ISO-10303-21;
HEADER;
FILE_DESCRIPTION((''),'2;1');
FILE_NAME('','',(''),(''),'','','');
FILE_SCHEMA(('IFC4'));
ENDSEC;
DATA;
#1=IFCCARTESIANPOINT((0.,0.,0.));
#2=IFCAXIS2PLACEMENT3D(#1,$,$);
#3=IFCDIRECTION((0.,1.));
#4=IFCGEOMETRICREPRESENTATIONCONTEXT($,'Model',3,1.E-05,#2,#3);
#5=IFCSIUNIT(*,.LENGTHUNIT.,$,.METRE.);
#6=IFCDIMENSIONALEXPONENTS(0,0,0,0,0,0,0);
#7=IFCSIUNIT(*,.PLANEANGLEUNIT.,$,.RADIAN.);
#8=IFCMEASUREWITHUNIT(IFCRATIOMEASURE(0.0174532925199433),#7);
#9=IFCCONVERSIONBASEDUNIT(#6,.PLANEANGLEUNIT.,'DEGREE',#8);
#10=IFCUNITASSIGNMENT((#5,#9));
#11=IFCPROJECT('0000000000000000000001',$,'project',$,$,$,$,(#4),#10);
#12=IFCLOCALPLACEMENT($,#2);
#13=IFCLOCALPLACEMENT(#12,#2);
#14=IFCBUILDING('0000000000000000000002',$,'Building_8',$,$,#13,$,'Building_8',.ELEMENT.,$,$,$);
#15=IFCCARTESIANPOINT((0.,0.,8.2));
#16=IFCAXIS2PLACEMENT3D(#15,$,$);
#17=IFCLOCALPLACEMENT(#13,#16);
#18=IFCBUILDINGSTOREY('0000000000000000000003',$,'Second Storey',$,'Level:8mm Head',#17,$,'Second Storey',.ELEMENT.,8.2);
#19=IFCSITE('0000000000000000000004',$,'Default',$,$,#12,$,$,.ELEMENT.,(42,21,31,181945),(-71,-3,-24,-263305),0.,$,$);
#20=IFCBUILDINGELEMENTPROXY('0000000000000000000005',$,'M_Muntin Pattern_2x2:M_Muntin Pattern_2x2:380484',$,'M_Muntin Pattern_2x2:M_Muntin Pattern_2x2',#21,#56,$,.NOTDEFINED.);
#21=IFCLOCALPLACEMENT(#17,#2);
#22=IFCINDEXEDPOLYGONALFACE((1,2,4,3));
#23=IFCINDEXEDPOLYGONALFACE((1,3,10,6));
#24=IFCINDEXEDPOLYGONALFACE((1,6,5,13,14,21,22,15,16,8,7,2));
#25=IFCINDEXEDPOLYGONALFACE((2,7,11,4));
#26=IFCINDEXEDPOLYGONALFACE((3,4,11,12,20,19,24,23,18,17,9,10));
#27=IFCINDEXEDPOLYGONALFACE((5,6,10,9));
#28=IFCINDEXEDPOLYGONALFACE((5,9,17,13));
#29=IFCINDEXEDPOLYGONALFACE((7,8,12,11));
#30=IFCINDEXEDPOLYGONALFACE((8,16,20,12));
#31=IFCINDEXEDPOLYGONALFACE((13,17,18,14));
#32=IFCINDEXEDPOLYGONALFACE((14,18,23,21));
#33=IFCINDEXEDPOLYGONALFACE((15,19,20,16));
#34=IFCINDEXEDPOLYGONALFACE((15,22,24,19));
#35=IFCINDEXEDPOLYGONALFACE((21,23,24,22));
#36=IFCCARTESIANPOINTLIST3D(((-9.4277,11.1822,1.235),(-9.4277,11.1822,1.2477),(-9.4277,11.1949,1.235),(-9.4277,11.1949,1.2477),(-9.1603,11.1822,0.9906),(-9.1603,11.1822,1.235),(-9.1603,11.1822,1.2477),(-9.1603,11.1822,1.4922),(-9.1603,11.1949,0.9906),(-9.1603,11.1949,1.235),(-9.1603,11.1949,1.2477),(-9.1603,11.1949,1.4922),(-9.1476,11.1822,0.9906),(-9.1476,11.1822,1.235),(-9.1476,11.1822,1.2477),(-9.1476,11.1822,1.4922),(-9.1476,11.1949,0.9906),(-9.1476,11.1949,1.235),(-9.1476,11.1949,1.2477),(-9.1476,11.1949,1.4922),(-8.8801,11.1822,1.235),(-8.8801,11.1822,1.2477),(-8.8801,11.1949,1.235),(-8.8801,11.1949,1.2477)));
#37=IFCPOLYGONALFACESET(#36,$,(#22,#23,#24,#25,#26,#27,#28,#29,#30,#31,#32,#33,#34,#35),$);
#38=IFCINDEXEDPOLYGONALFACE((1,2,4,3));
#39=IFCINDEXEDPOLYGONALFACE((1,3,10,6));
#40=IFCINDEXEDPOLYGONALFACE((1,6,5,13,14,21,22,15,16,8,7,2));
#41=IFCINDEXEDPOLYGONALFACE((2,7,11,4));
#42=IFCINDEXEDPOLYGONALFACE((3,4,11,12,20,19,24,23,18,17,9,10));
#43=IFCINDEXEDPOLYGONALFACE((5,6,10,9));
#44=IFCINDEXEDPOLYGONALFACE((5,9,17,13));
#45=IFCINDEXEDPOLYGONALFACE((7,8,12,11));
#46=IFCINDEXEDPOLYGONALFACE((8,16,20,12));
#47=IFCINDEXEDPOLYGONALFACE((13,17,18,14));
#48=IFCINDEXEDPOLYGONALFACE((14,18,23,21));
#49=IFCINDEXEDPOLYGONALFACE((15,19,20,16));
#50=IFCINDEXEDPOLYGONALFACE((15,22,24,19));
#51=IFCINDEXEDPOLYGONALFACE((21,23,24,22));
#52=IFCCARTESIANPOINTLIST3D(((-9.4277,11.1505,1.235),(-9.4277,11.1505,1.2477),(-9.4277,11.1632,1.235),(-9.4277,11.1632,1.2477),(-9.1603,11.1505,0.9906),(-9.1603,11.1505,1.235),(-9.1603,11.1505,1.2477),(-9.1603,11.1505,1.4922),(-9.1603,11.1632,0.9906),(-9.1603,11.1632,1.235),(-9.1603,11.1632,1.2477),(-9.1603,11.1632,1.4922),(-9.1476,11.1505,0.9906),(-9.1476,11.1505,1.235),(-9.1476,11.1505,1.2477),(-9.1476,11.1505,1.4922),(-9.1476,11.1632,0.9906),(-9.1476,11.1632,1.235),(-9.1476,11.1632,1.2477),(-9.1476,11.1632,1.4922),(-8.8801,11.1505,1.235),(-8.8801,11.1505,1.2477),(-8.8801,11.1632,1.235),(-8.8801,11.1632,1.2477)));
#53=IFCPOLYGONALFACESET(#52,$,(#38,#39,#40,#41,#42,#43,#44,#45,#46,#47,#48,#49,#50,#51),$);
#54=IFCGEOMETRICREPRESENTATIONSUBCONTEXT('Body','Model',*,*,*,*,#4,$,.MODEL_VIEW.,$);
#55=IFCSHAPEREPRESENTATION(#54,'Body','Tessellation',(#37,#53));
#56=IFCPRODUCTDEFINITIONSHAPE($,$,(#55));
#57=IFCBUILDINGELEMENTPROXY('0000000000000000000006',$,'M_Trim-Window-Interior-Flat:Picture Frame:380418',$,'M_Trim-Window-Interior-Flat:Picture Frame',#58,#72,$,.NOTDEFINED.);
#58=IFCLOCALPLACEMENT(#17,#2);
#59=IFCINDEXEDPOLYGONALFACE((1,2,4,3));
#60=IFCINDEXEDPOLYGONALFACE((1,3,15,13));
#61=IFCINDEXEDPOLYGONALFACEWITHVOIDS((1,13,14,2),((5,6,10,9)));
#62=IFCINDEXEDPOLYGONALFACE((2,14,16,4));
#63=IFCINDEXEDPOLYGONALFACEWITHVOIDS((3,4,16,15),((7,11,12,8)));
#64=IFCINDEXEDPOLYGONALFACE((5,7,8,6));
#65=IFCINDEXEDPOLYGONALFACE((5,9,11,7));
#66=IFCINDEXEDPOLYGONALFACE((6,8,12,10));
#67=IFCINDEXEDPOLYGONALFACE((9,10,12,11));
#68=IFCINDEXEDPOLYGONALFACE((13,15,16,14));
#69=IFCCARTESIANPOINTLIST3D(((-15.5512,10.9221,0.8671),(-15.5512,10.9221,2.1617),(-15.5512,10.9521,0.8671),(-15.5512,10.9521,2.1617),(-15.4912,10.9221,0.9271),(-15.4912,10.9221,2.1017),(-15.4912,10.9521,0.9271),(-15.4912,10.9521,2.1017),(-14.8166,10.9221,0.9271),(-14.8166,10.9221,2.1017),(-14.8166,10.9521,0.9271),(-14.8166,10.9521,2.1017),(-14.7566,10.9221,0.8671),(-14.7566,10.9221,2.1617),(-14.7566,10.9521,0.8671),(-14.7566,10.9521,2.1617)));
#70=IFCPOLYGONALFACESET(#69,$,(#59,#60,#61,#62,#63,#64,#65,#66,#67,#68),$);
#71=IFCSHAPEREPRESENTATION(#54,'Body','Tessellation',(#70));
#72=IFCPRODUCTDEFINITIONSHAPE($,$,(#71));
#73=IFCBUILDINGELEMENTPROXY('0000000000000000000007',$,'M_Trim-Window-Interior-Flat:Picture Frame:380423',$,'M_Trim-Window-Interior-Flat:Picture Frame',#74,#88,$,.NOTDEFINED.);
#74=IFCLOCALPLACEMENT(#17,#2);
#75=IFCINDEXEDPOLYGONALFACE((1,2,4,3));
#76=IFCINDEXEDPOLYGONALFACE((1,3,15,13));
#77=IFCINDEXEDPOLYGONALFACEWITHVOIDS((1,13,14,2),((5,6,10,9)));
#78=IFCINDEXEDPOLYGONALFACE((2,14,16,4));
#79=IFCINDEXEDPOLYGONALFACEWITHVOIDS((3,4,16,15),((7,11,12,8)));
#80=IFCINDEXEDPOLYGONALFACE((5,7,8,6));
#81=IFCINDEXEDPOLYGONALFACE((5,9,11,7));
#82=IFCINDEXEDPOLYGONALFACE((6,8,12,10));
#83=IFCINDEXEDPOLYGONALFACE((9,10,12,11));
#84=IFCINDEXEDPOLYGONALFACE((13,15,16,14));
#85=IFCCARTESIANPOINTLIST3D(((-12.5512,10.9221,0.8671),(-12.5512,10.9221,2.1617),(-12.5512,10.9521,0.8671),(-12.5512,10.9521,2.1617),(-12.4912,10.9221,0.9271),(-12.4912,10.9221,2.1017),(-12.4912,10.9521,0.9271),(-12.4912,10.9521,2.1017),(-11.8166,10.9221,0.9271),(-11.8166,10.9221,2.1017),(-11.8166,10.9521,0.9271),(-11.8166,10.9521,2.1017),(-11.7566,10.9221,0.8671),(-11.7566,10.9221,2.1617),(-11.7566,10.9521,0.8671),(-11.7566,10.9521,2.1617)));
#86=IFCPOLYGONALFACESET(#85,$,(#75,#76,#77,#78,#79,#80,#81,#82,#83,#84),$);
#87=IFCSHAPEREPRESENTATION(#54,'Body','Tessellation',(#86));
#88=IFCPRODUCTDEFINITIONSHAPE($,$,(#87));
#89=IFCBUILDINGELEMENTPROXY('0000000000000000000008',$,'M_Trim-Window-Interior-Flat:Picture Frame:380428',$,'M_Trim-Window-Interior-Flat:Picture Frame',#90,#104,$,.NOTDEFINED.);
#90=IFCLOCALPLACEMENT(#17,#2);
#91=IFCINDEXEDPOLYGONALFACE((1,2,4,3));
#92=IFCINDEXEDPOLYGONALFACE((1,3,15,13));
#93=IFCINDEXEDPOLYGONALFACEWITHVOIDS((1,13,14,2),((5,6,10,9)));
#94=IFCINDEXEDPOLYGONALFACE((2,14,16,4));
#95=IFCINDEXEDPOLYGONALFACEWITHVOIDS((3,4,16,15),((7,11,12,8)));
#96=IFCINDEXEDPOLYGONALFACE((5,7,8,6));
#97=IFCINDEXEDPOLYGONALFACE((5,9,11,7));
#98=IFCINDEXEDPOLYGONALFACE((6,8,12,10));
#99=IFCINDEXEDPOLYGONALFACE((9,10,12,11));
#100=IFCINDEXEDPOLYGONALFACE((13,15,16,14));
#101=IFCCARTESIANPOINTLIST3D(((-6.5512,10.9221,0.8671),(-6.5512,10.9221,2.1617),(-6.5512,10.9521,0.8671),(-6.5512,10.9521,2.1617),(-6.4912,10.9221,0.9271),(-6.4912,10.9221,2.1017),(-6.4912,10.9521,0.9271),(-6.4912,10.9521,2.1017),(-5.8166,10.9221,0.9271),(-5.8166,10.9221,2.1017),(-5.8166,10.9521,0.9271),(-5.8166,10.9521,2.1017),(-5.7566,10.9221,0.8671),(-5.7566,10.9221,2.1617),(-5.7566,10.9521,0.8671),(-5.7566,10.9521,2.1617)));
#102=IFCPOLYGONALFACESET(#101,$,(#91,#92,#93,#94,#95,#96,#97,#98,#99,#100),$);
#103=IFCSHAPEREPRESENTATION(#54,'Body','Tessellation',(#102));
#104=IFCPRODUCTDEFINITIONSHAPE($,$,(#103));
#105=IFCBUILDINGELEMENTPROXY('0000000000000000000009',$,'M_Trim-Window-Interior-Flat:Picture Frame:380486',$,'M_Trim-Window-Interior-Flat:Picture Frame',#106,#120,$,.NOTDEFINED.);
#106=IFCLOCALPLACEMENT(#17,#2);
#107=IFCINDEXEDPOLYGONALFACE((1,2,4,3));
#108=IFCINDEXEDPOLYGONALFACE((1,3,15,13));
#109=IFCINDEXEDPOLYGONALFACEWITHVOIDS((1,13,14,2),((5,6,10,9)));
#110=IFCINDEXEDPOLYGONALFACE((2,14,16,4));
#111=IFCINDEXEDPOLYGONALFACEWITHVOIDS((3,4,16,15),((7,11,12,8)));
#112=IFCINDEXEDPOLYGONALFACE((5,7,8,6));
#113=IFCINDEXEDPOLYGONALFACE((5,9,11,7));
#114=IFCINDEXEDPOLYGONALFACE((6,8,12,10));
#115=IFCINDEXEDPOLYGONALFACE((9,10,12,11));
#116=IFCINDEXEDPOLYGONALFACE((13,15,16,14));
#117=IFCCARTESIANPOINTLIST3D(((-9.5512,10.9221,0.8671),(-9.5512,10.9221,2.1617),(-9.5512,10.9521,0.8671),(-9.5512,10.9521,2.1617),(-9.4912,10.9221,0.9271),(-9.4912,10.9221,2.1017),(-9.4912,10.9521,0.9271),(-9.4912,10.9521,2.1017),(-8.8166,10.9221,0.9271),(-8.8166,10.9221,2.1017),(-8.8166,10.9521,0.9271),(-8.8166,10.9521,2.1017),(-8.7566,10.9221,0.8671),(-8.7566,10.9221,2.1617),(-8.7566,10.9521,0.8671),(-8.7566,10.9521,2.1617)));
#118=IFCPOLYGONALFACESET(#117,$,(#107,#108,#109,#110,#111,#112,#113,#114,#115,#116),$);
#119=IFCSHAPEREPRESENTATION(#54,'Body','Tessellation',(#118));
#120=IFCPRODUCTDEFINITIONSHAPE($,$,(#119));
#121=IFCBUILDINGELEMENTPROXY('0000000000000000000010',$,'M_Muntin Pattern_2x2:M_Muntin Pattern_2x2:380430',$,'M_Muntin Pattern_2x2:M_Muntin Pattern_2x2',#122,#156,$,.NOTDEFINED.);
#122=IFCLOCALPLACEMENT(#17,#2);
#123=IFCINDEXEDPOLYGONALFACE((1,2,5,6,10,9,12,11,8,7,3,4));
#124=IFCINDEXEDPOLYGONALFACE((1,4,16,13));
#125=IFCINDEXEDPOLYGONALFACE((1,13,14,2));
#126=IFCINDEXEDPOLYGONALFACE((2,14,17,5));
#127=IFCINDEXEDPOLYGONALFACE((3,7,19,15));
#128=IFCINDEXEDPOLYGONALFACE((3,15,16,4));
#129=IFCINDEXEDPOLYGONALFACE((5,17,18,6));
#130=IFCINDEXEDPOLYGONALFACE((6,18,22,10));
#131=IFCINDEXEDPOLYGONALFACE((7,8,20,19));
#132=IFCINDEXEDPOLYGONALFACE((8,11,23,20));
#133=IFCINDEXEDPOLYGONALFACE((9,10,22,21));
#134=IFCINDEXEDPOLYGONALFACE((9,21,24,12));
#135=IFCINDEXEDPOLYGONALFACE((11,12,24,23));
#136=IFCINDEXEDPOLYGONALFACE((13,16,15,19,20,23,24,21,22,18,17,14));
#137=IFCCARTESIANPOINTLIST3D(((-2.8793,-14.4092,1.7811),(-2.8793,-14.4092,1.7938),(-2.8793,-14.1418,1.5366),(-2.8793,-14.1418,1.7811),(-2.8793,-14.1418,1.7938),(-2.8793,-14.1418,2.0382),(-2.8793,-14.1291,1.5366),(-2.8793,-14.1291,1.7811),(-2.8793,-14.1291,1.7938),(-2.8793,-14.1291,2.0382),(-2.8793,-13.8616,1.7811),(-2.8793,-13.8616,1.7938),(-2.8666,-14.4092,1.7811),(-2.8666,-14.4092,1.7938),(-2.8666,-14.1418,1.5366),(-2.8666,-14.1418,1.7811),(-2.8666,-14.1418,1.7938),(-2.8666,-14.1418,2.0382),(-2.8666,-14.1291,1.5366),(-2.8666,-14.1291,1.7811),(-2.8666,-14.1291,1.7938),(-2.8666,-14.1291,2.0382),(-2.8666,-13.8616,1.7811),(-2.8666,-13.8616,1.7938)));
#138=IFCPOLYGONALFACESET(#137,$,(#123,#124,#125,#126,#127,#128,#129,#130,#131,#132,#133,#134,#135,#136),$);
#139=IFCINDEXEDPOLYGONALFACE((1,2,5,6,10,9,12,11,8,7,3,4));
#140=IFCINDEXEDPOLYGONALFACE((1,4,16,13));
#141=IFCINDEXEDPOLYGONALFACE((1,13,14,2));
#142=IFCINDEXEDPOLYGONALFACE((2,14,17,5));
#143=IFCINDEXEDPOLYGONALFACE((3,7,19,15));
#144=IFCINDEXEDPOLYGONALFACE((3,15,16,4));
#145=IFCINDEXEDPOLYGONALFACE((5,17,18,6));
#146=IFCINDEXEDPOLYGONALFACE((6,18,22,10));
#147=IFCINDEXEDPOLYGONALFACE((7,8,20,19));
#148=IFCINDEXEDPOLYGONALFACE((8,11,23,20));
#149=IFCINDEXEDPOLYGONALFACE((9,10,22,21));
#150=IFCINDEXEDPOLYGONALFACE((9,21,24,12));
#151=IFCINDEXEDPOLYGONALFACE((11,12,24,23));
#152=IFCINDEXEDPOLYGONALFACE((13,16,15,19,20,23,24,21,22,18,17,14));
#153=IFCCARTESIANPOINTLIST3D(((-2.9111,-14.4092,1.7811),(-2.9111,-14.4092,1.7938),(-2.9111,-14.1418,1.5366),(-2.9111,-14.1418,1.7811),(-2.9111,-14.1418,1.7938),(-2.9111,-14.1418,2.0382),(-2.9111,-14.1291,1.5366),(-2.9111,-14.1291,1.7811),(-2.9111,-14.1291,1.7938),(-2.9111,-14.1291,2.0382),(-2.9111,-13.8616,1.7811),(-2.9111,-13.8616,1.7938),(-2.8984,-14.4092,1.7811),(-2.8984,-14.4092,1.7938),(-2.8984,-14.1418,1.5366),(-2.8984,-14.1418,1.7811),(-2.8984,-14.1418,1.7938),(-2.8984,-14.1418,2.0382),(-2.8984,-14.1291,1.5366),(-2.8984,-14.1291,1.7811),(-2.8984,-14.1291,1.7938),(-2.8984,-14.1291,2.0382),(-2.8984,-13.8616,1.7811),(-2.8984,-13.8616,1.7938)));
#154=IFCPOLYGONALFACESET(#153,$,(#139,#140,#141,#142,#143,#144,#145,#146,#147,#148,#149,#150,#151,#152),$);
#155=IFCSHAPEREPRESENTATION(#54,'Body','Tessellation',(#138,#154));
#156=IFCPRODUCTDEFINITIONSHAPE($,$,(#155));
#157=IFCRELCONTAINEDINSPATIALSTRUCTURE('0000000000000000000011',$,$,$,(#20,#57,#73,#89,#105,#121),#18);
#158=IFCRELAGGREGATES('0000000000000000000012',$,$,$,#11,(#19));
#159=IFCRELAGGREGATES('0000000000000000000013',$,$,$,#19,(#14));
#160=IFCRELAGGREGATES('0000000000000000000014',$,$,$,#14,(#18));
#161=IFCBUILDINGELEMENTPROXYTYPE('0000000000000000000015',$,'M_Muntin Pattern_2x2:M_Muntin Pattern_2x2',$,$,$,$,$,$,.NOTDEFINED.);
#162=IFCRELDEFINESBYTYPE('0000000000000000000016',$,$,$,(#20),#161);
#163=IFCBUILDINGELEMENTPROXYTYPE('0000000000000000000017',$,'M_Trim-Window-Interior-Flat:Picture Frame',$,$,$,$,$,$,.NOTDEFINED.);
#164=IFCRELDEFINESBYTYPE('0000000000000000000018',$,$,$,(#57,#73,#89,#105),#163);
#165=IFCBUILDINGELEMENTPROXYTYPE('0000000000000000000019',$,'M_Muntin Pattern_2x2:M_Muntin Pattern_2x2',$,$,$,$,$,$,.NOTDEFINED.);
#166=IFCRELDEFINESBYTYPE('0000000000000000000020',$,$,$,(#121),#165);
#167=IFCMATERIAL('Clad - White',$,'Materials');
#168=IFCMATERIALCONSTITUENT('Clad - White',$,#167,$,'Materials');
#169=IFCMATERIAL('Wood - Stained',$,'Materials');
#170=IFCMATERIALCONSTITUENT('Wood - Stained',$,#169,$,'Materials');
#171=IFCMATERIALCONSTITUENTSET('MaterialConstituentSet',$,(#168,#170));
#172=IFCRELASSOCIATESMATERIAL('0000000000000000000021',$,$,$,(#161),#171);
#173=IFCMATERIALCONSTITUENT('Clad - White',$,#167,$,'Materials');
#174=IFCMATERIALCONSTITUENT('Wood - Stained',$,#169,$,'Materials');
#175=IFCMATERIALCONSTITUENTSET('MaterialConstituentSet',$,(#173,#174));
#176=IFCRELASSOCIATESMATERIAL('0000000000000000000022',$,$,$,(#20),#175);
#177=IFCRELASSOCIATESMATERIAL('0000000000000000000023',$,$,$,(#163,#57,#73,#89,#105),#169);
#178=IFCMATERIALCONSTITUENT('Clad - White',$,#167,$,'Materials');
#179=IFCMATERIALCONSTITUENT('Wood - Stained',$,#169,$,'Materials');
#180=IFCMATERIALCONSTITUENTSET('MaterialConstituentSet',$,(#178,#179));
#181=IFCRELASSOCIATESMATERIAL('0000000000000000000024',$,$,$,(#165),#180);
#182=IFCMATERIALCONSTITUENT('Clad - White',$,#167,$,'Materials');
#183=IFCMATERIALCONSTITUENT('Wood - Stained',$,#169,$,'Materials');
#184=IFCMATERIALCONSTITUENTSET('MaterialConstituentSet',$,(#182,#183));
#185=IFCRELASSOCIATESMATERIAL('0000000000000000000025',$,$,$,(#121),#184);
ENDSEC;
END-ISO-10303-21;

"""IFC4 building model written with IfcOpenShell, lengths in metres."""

from ifc_helpers import new_model, entity, si_unit, converted_unit, direction, frame, origin, place, context, subcontext, project, spatial, indexed_curve, outline, extrude, source, transform, mapped, material, constituent, constituent_set, type_object, type_shapes, element, save


model = new_model("IFC4")

# Units and contexts
model_context = context("Model", 3, precision=1e-05, world=origin(), true_north=direction((0.0, 1.0)))
body_context = subcontext(model_context, "Body", "Model", "MODEL_VIEW")
ifc_project = project(units=[si_unit("LENGTHUNIT", "METRE"), converted_unit("PLANEANGLEUNIT", "DEGREE", entity("IfcRatioMeasure", 0.0174532925199433), si_unit("PLANEANGLEUNIT", "RADIAN"), dimensions=[0, 0, 0, 0, 0, 0, 0])], contexts=[model_context])

# Site, building, storey
site_placement = place(None, origin())
site = spatial("IfcSite", under=ifc_project, at=site_placement, Name="Default", CompositionType="ELEMENT", RefLatitude=(42, 21, 31, 181945), RefLongitude=(-71, -3, -24, -263305), RefElevation=0.0)
building_placement = place(site_placement, origin())
building = spatial("IfcBuilding", under=site, at=building_placement, Name="Building_8", LongName="Building_8", CompositionType="ELEMENT")
storey_placement = place(building_placement, frame((0.0, 0.0, 8.2)))
storey = spatial("IfcBuildingStorey", under=building, at=storey_placement, Name="Second Storey", ObjectType="Level:8mm Head", LongName="Second Storey", CompositionType="ELEMENT", Elevation=8.2)

# Building element proxies
ifc_material_1 = material(Name="Clad - White", Category="Materials")
ifc_material_2 = material(Name="Wood - Stained", Category="Materials")
ifc_constituent_1 = constituent(ifc_material_1, Name="Clad - White", Category="Materials")
ifc_constituent_2 = constituent(ifc_material_2, Name="Wood - Stained", Category="Materials")
ifc_constituent_set_1 = constituent_set(constituents=[ifc_constituent_1, ifc_constituent_2], Name="MaterialConstituentSet")
building_element_proxy_type_1 = type_object("IfcBuildingElementProxyType", Name="M_Muntin Pattern_2x2:M_Muntin Pattern_2x2", PredefinedType="NOTDEFINED", material=ifc_constituent_set_1)
shared_shape_1 = source(origin(), body_context, "Body", "SweptSolid", [
    extrude(outline(indexed_curve([(0.0064, -0.0064), (0.2508, -0.0064), (0.2508, 0.0063), (0.0064, 0.0063), (0.0064, 0.2738), (-0.0063, 0.2738), (-0.0063, 0.0063), (-0.2508, 0.0063), (-0.2508, -0.0064), (-0.0063, -0.0064), (-0.0063, -0.2738), (0.0064, -0.2738), (0.0064, -0.0064)], self_intersect=False)), frame((0.0, -0.0222, 0.2508), z_axis=(0.0, 1.0, 0.0), x_axis=(0.0, 0.0, 1.0)), (0.0, 0.0, 1.0), 0.0127),
    extrude(outline(indexed_curve([(0.0064, -0.0064), (0.2508, -0.0064), (0.2508, 0.0063), (0.0064, 0.0063), (0.0064, 0.2738), (-0.0063, 0.2738), (-0.0063, 0.0063), (-0.2508, 0.0063), (-0.2508, -0.0064), (-0.0063, -0.0064), (-0.0063, -0.2738), (0.0064, -0.2738), (0.0064, -0.0064)], self_intersect=False)), frame((0.0, 0.0095, 0.2508), z_axis=(0.0, 1.0, 0.0), x_axis=(0.0, 0.0, 1.0)), (0.0, 0.0, 1.0), 0.0127),
])
type_shapes(building_element_proxy_type_1, [shared_shape_1])
ifc_constituent_3 = constituent(ifc_material_1, Name="Clad - White", Category="Materials")
ifc_constituent_4 = constituent(ifc_material_2, Name="Wood - Stained", Category="Materials")
ifc_constituent_set_2 = constituent_set(constituents=[ifc_constituent_3, ifc_constituent_4], Name="MaterialConstituentSet")
proxy_1_placement = place(storey_placement, frame((-9.1539, 11.1727, 0.9906), z_axis=(0.0, 0.0, 1.0), x_axis=(-1.0, 0.0, 0.0)))
element("IfcBuildingElementProxy", 1, at=proxy_1_placement, inside=storey, type_object=building_element_proxy_type_1, material=ifc_constituent_set_2, Name="M_Muntin Pattern_2x2:M_Muntin Pattern_2x2:380484", ObjectType="M_Muntin Pattern_2x2:M_Muntin Pattern_2x2", PredefinedType="NOTDEFINED", context=body_context, shape_type="MappedRepresentation", body=[
    mapped(shared_shape_1, transform((0.0, 0.0, 0.0), scale=1.0)),
])
building_element_proxy_type_2 = type_object("IfcBuildingElementProxyType", Name="M_Trim-Window-Interior-Flat:Picture Frame", PredefinedType="NOTDEFINED", material=ifc_material_2)
shared_shape_2 = source(origin(), body_context, "Body", "SweptSolid", [
    extrude(outline(indexed_curve([(-0.6473, -0.3973), (0.6473, -0.3973), (0.6473, 0.3973), (-0.6473, 0.3973), (-0.6473, -0.3973)], self_intersect=False), holes=[indexed_curve([(-0.5873, -0.3373), (-0.5873, 0.3373), (0.5873, 0.3373), (0.5873, -0.3373), (-0.5873, -0.3373)], self_intersect=False)]), frame((0.0, 0.6, 0.0), z_axis=(0.0, 0.0, 1.0), x_axis=(0.0, 1.0, 0.0)), (0.0, 0.0, 1.0), 0.03),
])
type_shapes(building_element_proxy_type_2, [shared_shape_2])
for number, where, z_axis, x_axis, name in (
    (2, (-15.1539, 10.9521, 2.1144), (0.0, -1.0, 0.0), (-1.0, 0.0, 0.0), "M_Trim-Window-Interior-Flat:Picture Frame:380418"),
    (3, (-12.1539, 10.9521, 2.1144), (0.0, -1.0, 0.0), (-1.0, 0.0, 0.0), "M_Trim-Window-Interior-Flat:Picture Frame:380423"),
    (4, (-6.1539, 10.9521, 2.1144), (0.0, -1.0, 0.0), (-1.0, 0.0, 0.0), "M_Trim-Window-Interior-Flat:Picture Frame:380428"),
    (5, (-9.1539, 10.9521, 2.1144), (0.0, -1.0, 0.0), (-1.0, 0.0, 0.0), "M_Trim-Window-Interior-Flat:Picture Frame:380486"),
):
    element("IfcBuildingElementProxy", number, at=place(storey_placement, frame(where, z_axis=z_axis, x_axis=x_axis)), inside=storey, type_object=building_element_proxy_type_2, material=ifc_material_2, Name=name, ObjectType="M_Trim-Window-Interior-Flat:Picture Frame", PredefinedType="NOTDEFINED", context=body_context, shape_type="MappedRepresentation", body=[
        mapped(shared_shape_2, transform((0.0, 0.0, 0.0), scale=1.0)),
    ])
ifc_constituent_5 = constituent(ifc_material_1, Name="Clad - White", Category="Materials")
ifc_constituent_6 = constituent(ifc_material_2, Name="Wood - Stained", Category="Materials")
ifc_constituent_set_3 = constituent_set(constituents=[ifc_constituent_5, ifc_constituent_6], Name="MaterialConstituentSet")
ifc_constituent_7 = constituent(ifc_material_1, Name="Clad - White", Category="Materials")
ifc_constituent_8 = constituent(ifc_material_2, Name="Wood - Stained", Category="Materials")
ifc_constituent_set_4 = constituent_set(constituents=[ifc_constituent_7, ifc_constituent_8], Name="MaterialConstituentSet")
building_element_proxy_type_3 = type_object("IfcBuildingElementProxyType", Name="M_Muntin Pattern_2x2:M_Muntin Pattern_2x2", PredefinedType="NOTDEFINED", material=ifc_constituent_set_4)
shared_shape_3 = source(origin(), body_context, "Body", "SweptSolid", [
    extrude(outline(indexed_curve([(0.0064, -0.0064), (0.2508, -0.0064), (0.2508, 0.0063), (0.0064, 0.0063), (0.0064, 0.2738), (-0.0063, 0.2738), (-0.0063, 0.0063), (-0.2508, 0.0063), (-0.2508, -0.0064), (-0.0063, -0.0064), (-0.0063, -0.2738), (0.0064, -0.2738), (0.0064, -0.0064)], self_intersect=False)), frame((0.0, 0.0095, 0.2508), z_axis=(0.0, 1.0, 0.0), x_axis=(0.0, 0.0, 1.0)), (0.0, 0.0, 1.0), 0.0127),
    extrude(outline(indexed_curve([(0.0064, -0.0064), (0.2508, -0.0064), (0.2508, 0.0063), (0.0064, 0.0063), (0.0064, 0.2738), (-0.0063, 0.2738), (-0.0063, 0.0063), (-0.2508, 0.0063), (-0.2508, -0.0064), (-0.0063, -0.0064), (-0.0063, -0.2738), (0.0064, -0.2738), (0.0064, -0.0064)], self_intersect=False)), frame((0.0, -0.0222, 0.2508), z_axis=(0.0, 1.0, 0.0), x_axis=(0.0, 0.0, 1.0)), (0.0, 0.0, 1.0), 0.0127),
])
type_shapes(building_element_proxy_type_3, [shared_shape_3])
proxy_2_placement = place(storey_placement, frame((-2.8888, -14.1354, 1.5366), z_axis=(0.0, 0.0, 1.0), x_axis=(0.0, -1.0, 0.0)))
element("IfcBuildingElementProxy", 6, at=proxy_2_placement, inside=storey, type_object=building_element_proxy_type_3, material=ifc_constituent_set_3, Name="M_Muntin Pattern_2x2:M_Muntin Pattern_2x2:380430", ObjectType="M_Muntin Pattern_2x2:M_Muntin Pattern_2x2", PredefinedType="NOTDEFINED", context=body_context, shape_type="MappedRepresentation", body=[
    mapped(shared_shape_3, transform((0.0, 0.0, 0.0), scale=1.0)),
])

save(model, "model.ifc")
